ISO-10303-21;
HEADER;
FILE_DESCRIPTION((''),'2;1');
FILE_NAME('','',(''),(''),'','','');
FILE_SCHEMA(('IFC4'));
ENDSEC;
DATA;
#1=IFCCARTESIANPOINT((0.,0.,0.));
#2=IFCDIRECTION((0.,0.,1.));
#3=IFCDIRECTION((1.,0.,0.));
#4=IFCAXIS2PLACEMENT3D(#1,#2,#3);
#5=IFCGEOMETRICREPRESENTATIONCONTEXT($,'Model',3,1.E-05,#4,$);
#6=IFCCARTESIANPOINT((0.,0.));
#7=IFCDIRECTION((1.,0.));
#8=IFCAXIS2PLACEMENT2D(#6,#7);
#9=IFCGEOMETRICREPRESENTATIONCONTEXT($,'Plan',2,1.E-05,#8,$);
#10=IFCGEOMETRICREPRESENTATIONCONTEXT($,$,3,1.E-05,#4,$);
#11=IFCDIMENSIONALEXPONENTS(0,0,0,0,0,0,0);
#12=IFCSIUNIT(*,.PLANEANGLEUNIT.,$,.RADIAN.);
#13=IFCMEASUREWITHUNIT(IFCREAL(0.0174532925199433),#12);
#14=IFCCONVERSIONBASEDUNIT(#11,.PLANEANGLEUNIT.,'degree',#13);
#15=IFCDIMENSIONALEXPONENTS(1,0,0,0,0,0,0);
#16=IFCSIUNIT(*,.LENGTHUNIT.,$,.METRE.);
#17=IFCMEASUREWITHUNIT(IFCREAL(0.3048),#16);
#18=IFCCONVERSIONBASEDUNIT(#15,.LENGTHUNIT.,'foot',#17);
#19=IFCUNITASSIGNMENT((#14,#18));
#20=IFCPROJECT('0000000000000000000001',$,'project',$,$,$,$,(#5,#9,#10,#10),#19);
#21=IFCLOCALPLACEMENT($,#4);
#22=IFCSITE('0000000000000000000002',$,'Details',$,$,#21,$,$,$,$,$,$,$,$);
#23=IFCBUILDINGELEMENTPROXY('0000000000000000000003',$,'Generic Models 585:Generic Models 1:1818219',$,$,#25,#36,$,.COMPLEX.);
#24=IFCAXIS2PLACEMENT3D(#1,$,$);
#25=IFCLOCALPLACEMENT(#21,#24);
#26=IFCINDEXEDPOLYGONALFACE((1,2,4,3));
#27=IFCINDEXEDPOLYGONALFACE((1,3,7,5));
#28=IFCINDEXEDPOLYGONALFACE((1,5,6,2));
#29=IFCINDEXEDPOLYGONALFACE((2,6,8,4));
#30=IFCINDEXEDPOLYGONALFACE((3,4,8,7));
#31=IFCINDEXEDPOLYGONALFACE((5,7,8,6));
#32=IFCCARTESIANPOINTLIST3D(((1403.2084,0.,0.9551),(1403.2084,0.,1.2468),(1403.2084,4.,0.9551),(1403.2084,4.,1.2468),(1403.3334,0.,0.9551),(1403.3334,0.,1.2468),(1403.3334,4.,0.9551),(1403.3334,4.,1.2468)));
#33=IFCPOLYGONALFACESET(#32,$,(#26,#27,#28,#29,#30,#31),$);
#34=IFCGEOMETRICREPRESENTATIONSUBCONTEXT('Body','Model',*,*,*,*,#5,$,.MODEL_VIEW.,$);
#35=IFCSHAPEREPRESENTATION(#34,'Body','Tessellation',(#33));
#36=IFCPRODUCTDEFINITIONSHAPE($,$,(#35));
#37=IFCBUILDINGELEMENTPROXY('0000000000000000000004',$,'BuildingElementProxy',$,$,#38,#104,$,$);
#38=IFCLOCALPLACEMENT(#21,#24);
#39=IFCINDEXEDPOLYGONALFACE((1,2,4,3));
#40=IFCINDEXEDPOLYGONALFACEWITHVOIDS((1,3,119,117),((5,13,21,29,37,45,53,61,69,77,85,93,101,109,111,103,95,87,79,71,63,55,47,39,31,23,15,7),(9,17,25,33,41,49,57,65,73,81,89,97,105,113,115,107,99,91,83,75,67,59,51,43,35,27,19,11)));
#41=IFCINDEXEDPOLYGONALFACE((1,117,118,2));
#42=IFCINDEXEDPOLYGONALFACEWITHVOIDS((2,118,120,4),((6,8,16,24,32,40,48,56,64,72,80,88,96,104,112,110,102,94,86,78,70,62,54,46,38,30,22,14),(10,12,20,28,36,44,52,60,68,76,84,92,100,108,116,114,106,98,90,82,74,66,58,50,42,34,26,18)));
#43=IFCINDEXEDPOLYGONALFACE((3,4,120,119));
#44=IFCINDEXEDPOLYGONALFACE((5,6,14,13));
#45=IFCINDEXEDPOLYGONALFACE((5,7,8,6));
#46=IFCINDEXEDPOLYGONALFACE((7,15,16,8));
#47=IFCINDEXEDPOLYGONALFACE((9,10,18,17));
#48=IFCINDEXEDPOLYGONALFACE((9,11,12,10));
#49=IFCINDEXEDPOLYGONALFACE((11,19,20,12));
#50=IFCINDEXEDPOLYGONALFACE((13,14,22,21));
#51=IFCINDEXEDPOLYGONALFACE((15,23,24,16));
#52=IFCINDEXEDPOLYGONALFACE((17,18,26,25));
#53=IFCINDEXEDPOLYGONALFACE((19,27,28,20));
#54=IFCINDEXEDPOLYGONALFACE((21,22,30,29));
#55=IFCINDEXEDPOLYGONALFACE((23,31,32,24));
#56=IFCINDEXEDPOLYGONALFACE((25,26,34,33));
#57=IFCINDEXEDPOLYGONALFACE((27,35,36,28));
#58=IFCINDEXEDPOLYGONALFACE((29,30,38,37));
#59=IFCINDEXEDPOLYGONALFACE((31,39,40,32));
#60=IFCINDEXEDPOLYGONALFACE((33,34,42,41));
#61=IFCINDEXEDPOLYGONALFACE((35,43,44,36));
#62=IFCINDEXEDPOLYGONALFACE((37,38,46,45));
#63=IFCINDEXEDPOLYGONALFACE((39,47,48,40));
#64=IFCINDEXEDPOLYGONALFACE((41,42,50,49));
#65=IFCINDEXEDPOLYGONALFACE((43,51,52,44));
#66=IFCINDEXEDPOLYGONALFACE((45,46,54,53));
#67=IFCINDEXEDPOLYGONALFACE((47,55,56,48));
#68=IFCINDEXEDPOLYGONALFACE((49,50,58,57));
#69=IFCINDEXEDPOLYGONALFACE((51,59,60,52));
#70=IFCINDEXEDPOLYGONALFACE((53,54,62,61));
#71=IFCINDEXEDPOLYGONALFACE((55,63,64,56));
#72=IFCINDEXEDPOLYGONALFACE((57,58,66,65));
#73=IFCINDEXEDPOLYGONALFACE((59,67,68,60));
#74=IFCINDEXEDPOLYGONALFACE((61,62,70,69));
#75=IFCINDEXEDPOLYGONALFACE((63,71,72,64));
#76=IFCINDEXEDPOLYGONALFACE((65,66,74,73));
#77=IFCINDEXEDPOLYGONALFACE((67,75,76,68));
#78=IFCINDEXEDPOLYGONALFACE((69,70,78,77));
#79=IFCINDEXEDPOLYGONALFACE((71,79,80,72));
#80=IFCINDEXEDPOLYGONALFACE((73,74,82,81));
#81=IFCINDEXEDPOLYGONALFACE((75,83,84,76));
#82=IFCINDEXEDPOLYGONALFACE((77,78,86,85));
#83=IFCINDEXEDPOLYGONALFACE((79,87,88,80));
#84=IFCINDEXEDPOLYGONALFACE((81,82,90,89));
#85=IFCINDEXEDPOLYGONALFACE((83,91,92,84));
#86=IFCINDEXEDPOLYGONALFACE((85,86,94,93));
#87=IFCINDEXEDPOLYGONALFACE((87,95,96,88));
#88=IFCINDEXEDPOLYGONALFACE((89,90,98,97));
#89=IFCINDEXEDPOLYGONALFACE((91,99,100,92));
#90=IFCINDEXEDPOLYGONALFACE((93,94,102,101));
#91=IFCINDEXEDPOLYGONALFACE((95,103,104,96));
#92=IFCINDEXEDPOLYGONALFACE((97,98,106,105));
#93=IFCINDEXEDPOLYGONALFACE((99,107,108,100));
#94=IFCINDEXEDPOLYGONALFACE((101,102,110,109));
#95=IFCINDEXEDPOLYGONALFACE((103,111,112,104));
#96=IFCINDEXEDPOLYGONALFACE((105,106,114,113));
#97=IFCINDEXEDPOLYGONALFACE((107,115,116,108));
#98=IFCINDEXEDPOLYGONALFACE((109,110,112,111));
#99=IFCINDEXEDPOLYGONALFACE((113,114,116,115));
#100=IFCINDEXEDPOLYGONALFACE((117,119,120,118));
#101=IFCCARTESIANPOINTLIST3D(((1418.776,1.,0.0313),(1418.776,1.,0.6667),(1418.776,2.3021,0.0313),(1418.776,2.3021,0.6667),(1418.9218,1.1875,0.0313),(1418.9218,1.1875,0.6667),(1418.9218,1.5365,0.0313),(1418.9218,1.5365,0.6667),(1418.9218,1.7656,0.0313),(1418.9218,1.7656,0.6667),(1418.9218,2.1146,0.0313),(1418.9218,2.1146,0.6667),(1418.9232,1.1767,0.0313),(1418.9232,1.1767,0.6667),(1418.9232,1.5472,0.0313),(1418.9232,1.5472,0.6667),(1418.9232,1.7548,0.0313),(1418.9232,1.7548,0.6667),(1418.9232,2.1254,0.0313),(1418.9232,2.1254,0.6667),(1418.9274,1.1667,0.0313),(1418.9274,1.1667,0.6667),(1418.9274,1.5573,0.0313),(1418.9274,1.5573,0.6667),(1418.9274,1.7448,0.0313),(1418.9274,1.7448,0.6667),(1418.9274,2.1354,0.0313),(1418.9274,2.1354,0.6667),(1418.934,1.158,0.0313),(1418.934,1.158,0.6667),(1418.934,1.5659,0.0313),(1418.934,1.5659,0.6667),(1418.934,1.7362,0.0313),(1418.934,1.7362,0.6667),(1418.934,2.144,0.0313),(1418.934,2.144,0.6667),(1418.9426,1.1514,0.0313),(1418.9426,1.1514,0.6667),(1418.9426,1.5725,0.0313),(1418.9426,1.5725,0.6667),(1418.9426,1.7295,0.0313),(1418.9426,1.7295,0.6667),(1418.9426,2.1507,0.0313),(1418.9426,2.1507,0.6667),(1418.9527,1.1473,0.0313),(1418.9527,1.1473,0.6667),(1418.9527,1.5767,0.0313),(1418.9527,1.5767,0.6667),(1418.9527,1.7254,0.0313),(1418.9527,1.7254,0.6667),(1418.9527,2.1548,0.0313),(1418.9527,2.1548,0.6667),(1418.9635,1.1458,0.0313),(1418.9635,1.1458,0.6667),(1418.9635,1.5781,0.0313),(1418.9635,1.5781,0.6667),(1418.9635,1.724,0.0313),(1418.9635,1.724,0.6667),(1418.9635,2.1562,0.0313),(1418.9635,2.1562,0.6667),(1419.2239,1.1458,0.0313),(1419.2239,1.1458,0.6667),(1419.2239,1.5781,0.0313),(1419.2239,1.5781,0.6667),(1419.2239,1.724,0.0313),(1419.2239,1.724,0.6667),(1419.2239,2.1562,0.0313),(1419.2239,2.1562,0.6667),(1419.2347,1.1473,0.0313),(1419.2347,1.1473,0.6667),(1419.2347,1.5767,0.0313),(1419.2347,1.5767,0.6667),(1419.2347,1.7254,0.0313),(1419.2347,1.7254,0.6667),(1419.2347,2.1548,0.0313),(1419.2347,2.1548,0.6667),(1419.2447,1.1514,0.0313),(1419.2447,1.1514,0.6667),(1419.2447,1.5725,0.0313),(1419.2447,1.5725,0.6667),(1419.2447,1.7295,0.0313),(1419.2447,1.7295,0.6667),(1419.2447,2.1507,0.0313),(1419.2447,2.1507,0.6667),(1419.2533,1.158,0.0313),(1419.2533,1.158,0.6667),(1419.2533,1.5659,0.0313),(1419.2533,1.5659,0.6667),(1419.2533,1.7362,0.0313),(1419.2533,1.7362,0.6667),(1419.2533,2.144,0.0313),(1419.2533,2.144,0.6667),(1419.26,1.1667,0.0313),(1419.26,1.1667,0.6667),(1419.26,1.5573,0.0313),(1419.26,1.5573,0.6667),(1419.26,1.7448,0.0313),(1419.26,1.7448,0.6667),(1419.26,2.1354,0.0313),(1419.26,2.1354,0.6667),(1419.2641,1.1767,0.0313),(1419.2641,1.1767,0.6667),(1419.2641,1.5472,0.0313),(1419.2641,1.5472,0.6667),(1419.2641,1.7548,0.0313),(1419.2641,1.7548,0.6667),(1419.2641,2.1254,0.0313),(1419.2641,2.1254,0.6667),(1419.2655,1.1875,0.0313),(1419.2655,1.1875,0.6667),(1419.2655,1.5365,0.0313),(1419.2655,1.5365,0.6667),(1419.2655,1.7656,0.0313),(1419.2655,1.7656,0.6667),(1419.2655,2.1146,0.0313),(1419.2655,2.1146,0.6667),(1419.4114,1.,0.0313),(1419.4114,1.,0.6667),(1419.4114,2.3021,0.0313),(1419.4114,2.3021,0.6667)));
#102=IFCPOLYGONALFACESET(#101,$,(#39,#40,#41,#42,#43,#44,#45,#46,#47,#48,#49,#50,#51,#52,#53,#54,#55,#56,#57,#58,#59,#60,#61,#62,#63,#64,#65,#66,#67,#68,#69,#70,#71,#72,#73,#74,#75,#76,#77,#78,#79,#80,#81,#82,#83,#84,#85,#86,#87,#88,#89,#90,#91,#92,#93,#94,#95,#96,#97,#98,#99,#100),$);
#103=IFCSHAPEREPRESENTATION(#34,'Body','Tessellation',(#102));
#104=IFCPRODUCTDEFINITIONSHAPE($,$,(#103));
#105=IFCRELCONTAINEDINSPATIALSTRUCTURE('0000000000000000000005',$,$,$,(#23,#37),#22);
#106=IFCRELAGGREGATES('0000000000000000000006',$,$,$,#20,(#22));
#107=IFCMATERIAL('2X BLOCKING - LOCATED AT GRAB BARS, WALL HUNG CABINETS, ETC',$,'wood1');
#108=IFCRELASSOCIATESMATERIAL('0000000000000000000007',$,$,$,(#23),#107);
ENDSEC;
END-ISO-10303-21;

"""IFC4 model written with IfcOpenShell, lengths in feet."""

from ifc_helpers import new_model, entity, si_unit, converted_unit, frame, origin_with_axes, origin_2d_with_axis, place, context, subcontext, project, spatial, polyline, line, indexed_curve, outline, extrude, material, element, save


model = new_model("IFC4")

# Units and contexts
model_context = context("Model", 3, precision=1e-05, world=origin_with_axes())
plan_context = context("Plan", 2, precision=1e-05, world=origin_2d_with_axis())
context_of_model = context(None, 3, precision=1e-05, world=origin_with_axes())
body_context = subcontext(model_context, "Body", "Model", "MODEL_VIEW")
ifc_project = project(units=[converted_unit("PLANEANGLEUNIT", "degree", entity("IfcReal", 0.0174532925199433), si_unit("PLANEANGLEUNIT", "RADIAN"), dimensions=[0, 0, 0, 0, 0, 0, 0]), converted_unit("LENGTHUNIT", "foot", entity("IfcReal", 0.3048), si_unit("LENGTHUNIT", "METRE"), dimensions=[1, 0, 0, 0, 0, 0, 0])], contexts=[model_context, plan_context, context_of_model, context_of_model])

# Site
site_placement = place(None, origin_with_axes())
site = spatial("IfcSite", under=ifc_project, at=site_placement, Name="Details")

# Building element proxies
ifc_material_1 = material(Name="2X BLOCKING - LOCATED AT GRAB BARS, WALL HUNG CABINETS, ETC", Category="wood1")
proxy_1_placement = place(site_placement, frame((1403.2084, 0.0, 0.9551), z_axis=(0.0, 0.0, 1.0), x_axis=(0.0, 1.0, 0.0)))
element("IfcBuildingElementProxy", 1, at=proxy_1_placement, inside=site, material=ifc_material_1, Name="Generic Models 585:Generic Models 1:1818219", PredefinedType="COMPLEX", context=body_context, shape_type="SweptSolid", body=[
    extrude(outline(polyline([(-2.0, -0.0625), (2.0, -0.0625), (2.0, 0.0625), (-2.0, 0.0625), (-2.0, -0.0625)])), frame((2.0, -0.0625, 0.0), z_axis=(0.0, 0.0, -1.0), x_axis=(1.0, 0.0, 0.0)), (0.0, 0.0, -1.0), 0.2917),
])
proxy_2_placement = place(site_placement, frame((1419.0936, 2.3021, 0.0313), z_axis=(0.0, 0.0, 1.0), x_axis=(0.0, 1.0, 0.0)))
element("IfcBuildingElementProxy", 2, at=proxy_2_placement, inside=site, Name="BuildingElementProxy", context=body_context, shape_type="SweptSolid", body=[
    extrude(outline(indexed_curve([(-0.3177, -0.651), (0.3177, -0.651), (0.3177, 0.651), (-0.3177, 0.651), (0.1719, -0.1146), (0.1719, -0.4635), (0.1705, -0.4743), (0.1663, -0.4844), (0.1597, -0.493), (0.151, -0.4996), (0.141, -0.5038), (0.1302, -0.5052), (-0.1302, -0.5052), (-0.141, -0.5038), (-0.151, -0.4996), (-0.1597, -0.493), (-0.1663, -0.4844), (-0.1705, -0.4743), (-0.1719, -0.4635), (-0.1719, -0.1146), (-0.1705, -0.1038), (-0.1663, -0.0938), (-0.1597, -0.0851), (-0.151, -0.0785), (-0.141, -0.0743), (-0.1302, -0.0729), (0.1302, -0.0729), (0.141, -0.0743), (0.151, -0.0785), (0.1597, -0.0851), (0.1663, -0.0938), (0.1705, -0.1038), (0.151, 0.0785), (0.141, 0.0743), (0.1302, 0.0729), (-0.1302, 0.0729), (-0.141, 0.0743), (-0.151, 0.0785), (-0.1597, 0.0851), (-0.1663, 0.0937), (-0.1705, 0.1038), (-0.1719, 0.1146), (-0.1719, 0.4635), (-0.1705, 0.4743), (-0.1663, 0.4844), (-0.1597, 0.493), (-0.151, 0.4996), (-0.141, 0.5038), (-0.1302, 0.5052), (0.1302, 0.5052), (0.141, 0.5038), (0.151, 0.4996), (0.1597, 0.493), (0.1663, 0.4844), (0.1705, 0.4743), (0.1719, 0.4635), (0.1719, 0.1146), (0.1705, 0.1038), (0.1663, 0.0937), (0.1597, 0.0851)], segments=[line(4, 3), line(3, 2), line(2, 1), line(1, 4)], self_intersect=False), holes=[indexed_curve([(-0.3177, -0.651), (0.3177, -0.651), (0.3177, 0.651), (-0.3177, 0.651), (0.1719, -0.1146), (0.1719, -0.4635), (0.1705, -0.4743), (0.1663, -0.4844), (0.1597, -0.493), (0.151, -0.4996), (0.141, -0.5038), (0.1302, -0.5052), (-0.1302, -0.5052), (-0.141, -0.5038), (-0.151, -0.4996), (-0.1597, -0.493), (-0.1663, -0.4844), (-0.1705, -0.4743), (-0.1719, -0.4635), (-0.1719, -0.1146), (-0.1705, -0.1038), (-0.1663, -0.0938), (-0.1597, -0.0851), (-0.151, -0.0785), (-0.141, -0.0743), (-0.1302, -0.0729), (0.1302, -0.0729), (0.141, -0.0743), (0.151, -0.0785), (0.1597, -0.0851), (0.1663, -0.0938), (0.1705, -0.1038), (0.151, 0.0785), (0.141, 0.0743), (0.1302, 0.0729), (-0.1302, 0.0729), (-0.141, 0.0743), (-0.151, 0.0785), (-0.1597, 0.0851), (-0.1663, 0.0937), (-0.1705, 0.1038), (-0.1719, 0.1146), (-0.1719, 0.4635), (-0.1705, 0.4743), (-0.1663, 0.4844), (-0.1597, 0.493), (-0.151, 0.4996), (-0.141, 0.5038), (-0.1302, 0.5052), (0.1302, 0.5052), (0.141, 0.5038), (0.151, 0.4996), (0.1597, 0.493), (0.1663, 0.4844), (0.1705, 0.4743), (0.1719, 0.4635), (0.1719, 0.1146), (0.1705, 0.1038), (0.1663, 0.0937), (0.1597, 0.0851)], segments=[line(20, 19), line(19, 18), line(18, 17), line(17, 16), line(16, 15), line(15, 14), line(14, 13), line(13, 12), line(12, 11), line(11, 10), line(10, 9), line(9, 8), line(8, 7), line(7, 6), line(6, 5), line(5, 32), line(32, 31), line(31, 30), line(30, 29), line(29, 28), line(28, 27), line(27, 26), line(26, 25), line(25, 24), line(24, 23), line(23, 22), line(22, 21), line(21, 20)], self_intersect=False), indexed_curve([(-0.3177, -0.651), (0.3177, -0.651), (0.3177, 0.651), (-0.3177, 0.651), (0.1719, -0.1146), (0.1719, -0.4635), (0.1705, -0.4743), (0.1663, -0.4844), (0.1597, -0.493), (0.151, -0.4996), (0.141, -0.5038), (0.1302, -0.5052), (-0.1302, -0.5052), (-0.141, -0.5038), (-0.151, -0.4996), (-0.1597, -0.493), (-0.1663, -0.4844), (-0.1705, -0.4743), (-0.1719, -0.4635), (-0.1719, -0.1146), (-0.1705, -0.1038), (-0.1663, -0.0938), (-0.1597, -0.0851), (-0.151, -0.0785), (-0.141, -0.0743), (-0.1302, -0.0729), (0.1302, -0.0729), (0.141, -0.0743), (0.151, -0.0785), (0.1597, -0.0851), (0.1663, -0.0938), (0.1705, -0.1038), (0.151, 0.0785), (0.141, 0.0743), (0.1302, 0.0729), (-0.1302, 0.0729), (-0.141, 0.0743), (-0.151, 0.0785), (-0.1597, 0.0851), (-0.1663, 0.0937), (-0.1705, 0.1038), (-0.1719, 0.1146), (-0.1719, 0.4635), (-0.1705, 0.4743), (-0.1663, 0.4844), (-0.1597, 0.493), (-0.151, 0.4996), (-0.141, 0.5038), (-0.1302, 0.5052), (0.1302, 0.5052), (0.141, 0.5038), (0.151, 0.4996), (0.1597, 0.493), (0.1663, 0.4844), (0.1705, 0.4743), (0.1719, 0.4635), (0.1719, 0.1146), (0.1705, 0.1038), (0.1663, 0.0937), (0.1597, 0.0851)], segments=[line(44, 43), line(43, 42), line(42, 41), line(41, 40), line(40, 39), line(39, 38), line(38, 37), line(37, 36), line(36, 35), line(35, 34), line(34, 33), line(33, 60), line(60, 59), line(59, 58), line(58, 57), line(57, 56), line(56, 55), line(55, 54), line(54, 53), line(53, 52), line(52, 51), line(51, 50), line(50, 49), line(49, 48), line(48, 47), line(47, 46), line(46, 45), line(45, 44)], self_intersect=False)]), frame((-0.651, 0.0, 0.0), z_axis=(0.0, 0.0, 1.0), x_axis=(0.0, -1.0, 0.0)), (0.0, 0.0, 1.0), 0.6354),
])

save(model, "model.ifc")
